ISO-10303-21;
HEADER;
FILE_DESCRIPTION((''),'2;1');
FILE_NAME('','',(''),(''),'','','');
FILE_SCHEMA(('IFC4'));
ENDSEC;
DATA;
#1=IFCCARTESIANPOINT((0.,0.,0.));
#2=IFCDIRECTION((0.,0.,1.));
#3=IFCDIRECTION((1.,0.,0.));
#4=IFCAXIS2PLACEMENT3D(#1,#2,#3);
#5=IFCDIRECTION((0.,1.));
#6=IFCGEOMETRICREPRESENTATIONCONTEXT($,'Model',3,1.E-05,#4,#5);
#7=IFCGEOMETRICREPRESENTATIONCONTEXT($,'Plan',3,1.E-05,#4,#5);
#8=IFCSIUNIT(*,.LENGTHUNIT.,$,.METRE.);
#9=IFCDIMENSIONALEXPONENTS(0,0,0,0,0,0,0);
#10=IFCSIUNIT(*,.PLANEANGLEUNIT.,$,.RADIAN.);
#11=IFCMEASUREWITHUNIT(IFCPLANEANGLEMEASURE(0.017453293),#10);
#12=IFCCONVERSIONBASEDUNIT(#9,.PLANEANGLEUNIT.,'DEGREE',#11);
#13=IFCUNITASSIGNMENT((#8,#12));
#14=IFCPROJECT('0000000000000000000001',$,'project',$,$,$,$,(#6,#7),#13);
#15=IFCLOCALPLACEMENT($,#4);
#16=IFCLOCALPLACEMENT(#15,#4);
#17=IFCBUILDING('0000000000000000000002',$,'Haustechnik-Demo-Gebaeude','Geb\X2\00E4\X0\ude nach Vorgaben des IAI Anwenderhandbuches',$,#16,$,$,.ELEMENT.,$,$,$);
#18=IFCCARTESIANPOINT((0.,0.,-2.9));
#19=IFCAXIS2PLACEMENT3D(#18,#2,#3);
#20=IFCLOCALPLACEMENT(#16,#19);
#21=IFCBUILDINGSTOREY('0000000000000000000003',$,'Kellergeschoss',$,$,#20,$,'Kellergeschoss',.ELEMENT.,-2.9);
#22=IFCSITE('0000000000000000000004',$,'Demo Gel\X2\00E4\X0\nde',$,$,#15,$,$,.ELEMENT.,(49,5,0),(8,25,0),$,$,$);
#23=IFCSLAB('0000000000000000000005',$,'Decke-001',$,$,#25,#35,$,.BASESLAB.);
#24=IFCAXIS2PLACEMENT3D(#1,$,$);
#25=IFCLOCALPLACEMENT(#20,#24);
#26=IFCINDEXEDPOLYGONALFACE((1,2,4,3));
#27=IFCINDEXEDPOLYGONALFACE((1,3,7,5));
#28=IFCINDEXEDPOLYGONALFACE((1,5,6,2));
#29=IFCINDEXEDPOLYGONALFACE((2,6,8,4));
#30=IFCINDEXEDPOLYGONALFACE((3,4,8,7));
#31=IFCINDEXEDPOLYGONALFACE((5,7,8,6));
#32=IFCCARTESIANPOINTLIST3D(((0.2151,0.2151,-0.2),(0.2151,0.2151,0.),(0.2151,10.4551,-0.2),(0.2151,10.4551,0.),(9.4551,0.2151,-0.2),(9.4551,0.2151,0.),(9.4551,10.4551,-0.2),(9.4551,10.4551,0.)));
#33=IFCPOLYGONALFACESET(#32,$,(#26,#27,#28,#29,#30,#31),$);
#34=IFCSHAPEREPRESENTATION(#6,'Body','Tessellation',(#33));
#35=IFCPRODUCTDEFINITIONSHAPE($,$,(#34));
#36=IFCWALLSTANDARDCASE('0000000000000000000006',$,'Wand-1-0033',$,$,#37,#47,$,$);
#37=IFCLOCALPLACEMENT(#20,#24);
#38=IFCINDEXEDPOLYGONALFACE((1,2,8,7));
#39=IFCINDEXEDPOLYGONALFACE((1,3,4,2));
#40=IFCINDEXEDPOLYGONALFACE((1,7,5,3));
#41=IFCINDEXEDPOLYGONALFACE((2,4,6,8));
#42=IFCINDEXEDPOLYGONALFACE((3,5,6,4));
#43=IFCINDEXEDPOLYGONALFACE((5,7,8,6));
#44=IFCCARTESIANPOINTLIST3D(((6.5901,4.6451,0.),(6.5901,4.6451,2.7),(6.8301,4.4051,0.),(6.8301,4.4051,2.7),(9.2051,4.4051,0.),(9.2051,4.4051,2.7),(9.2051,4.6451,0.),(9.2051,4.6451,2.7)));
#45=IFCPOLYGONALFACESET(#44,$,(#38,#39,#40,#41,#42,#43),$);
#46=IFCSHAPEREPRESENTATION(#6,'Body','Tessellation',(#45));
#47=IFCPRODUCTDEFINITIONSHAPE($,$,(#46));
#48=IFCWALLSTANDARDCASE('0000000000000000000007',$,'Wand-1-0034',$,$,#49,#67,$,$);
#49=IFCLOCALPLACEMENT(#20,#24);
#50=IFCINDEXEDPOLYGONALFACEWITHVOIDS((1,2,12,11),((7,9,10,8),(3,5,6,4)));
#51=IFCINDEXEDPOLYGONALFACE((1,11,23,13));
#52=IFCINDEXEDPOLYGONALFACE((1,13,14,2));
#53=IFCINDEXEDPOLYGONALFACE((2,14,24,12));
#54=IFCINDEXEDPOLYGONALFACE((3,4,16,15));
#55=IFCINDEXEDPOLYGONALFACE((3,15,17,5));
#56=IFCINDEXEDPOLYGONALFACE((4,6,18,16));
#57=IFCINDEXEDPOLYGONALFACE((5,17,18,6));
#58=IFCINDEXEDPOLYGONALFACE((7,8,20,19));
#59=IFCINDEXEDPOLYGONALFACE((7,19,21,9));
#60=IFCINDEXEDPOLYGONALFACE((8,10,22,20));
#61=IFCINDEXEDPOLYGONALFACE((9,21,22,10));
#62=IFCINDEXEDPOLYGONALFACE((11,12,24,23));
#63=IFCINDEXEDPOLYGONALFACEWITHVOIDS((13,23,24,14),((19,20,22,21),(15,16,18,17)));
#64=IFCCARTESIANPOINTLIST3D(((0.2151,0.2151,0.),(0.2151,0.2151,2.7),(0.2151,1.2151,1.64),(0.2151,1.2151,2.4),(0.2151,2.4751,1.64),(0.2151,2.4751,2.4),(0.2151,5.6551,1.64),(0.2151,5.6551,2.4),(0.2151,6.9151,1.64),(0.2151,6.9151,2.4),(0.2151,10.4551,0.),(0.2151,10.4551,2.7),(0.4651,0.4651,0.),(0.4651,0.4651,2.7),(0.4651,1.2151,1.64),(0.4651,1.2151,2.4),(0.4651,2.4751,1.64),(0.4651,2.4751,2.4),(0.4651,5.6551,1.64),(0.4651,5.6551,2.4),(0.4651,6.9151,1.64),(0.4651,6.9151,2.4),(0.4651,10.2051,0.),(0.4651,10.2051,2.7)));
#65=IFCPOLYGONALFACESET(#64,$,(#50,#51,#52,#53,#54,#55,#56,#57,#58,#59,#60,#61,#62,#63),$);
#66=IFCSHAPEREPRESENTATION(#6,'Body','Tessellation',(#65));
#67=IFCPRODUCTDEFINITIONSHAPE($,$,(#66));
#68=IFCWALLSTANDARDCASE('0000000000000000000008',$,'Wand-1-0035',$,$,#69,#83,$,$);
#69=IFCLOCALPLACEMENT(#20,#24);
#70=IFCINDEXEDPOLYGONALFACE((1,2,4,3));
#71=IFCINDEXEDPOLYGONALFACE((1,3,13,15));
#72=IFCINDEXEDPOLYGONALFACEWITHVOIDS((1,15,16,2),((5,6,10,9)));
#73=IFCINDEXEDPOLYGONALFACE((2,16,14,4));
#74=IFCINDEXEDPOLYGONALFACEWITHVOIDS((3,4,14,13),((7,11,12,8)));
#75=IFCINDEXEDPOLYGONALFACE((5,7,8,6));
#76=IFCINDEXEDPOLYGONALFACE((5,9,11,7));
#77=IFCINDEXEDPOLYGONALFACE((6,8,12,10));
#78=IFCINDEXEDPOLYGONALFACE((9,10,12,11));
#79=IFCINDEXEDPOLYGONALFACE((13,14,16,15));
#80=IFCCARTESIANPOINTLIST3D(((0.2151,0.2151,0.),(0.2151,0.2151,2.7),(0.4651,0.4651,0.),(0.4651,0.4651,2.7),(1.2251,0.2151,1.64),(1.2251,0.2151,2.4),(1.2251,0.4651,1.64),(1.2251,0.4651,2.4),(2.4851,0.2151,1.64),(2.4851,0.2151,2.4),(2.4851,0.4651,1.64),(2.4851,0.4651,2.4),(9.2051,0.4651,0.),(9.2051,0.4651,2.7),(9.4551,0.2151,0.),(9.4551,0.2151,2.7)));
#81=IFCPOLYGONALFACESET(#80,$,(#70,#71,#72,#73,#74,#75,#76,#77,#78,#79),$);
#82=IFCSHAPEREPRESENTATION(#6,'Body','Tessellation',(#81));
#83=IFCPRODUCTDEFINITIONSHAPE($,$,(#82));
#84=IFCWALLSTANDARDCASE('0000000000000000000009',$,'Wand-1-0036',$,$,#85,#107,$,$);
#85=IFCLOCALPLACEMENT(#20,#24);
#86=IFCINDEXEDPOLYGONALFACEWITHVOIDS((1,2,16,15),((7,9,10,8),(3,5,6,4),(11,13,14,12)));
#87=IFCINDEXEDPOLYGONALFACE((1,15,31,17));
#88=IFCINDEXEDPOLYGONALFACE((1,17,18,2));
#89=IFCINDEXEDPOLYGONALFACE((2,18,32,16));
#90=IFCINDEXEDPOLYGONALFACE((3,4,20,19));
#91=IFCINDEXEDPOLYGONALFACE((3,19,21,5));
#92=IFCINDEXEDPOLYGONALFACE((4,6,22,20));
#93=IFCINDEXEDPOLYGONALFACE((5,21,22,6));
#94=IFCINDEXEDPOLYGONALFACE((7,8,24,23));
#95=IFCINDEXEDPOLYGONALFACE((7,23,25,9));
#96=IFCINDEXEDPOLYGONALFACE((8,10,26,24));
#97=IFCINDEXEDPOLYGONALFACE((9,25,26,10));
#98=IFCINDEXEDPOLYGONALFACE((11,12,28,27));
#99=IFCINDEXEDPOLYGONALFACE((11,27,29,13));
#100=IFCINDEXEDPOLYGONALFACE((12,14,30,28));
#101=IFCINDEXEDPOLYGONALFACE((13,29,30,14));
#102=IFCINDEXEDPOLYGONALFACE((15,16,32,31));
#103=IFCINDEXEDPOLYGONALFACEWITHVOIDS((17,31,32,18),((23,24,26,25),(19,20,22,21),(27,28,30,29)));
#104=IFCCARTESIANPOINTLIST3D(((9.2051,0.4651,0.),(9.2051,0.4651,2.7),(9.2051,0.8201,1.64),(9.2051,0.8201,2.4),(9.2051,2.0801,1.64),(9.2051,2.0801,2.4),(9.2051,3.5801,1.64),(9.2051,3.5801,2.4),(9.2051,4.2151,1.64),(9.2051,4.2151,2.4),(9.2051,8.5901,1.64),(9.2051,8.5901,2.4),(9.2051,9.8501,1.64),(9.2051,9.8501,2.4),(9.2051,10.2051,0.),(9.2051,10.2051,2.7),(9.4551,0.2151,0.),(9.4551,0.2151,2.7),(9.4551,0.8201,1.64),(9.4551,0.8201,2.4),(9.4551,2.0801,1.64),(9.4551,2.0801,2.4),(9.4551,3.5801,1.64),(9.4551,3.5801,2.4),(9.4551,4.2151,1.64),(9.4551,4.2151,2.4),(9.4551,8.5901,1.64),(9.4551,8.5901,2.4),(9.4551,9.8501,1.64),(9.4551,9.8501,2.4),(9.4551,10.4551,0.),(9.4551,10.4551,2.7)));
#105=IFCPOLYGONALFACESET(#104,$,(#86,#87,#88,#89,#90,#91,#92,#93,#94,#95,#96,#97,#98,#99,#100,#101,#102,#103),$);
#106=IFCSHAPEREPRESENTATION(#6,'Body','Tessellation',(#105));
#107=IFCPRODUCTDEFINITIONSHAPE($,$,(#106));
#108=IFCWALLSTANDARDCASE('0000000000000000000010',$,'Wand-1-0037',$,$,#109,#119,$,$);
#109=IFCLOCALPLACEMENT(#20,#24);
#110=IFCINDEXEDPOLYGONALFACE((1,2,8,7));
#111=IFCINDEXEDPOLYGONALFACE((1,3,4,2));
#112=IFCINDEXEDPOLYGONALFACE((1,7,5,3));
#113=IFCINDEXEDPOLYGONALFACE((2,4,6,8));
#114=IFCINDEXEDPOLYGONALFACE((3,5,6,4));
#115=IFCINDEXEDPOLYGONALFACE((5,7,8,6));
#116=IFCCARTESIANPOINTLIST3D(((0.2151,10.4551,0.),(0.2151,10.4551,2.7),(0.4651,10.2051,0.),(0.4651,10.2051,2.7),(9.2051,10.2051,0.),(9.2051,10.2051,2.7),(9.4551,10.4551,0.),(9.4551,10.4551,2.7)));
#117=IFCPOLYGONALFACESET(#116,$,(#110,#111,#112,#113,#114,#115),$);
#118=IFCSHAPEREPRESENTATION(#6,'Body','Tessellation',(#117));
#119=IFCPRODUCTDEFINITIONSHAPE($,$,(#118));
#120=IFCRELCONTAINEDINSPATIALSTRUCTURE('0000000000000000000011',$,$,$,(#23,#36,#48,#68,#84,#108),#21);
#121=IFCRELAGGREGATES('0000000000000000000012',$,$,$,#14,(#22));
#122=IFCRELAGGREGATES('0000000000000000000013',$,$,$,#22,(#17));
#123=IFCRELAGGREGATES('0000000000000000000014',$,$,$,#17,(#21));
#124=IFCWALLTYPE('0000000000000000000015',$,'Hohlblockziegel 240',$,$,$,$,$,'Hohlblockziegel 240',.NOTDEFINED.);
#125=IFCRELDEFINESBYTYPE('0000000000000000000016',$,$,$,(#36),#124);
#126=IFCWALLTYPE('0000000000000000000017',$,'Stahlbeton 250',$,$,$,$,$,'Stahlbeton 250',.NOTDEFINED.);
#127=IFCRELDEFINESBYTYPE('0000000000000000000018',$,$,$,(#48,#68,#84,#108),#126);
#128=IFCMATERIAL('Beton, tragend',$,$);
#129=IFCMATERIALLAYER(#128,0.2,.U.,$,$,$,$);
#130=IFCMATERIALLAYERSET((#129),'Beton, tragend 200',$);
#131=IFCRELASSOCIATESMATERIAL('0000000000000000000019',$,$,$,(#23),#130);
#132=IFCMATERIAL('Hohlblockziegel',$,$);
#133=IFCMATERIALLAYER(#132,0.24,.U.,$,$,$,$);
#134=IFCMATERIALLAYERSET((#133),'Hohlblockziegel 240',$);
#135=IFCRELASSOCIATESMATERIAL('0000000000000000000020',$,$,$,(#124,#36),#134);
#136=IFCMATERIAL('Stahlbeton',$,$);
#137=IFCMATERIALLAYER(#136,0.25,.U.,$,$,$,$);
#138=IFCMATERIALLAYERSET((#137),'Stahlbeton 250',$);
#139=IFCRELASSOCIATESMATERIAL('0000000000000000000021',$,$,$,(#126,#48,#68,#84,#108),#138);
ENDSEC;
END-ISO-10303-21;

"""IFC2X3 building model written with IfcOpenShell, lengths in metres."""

from ifc_helpers import new_model, entity, si_unit, converted_unit, direction, frame, frame_2d, origin_with_axes, place, context, project, spatial, polyline, rectangle, outline, extrude, material, layer, layer_set, layer_usage, type_object, element, save


model = new_model("IFC2X3")

# Units and contexts
model_context = context("Model", 3, precision=1e-05, world=origin_with_axes(), true_north=direction((0.0, 1.0)))
plan_context = context("Plan", 3, precision=1e-05, world=origin_with_axes(), true_north=direction((0.0, 1.0)))
ifc_project = project(units=[si_unit("LENGTHUNIT", "METRE"), converted_unit("PLANEANGLEUNIT", "DEGREE", entity("IfcPlaneAngleMeasure", 0.017453293), si_unit("PLANEANGLEUNIT", "RADIAN"), dimensions=[0, 0, 0, 0, 0, 0, 0])], contexts=[model_context, plan_context])

# Site, building, storey
site_placement = place(None, origin_with_axes())
site = spatial("IfcSite", under=ifc_project, at=site_placement, Name="Demo Gelände", CompositionType="ELEMENT", RefLatitude=(49, 5, 0), RefLongitude=(8, 25, 0))
building_placement = place(site_placement, origin_with_axes())
building = spatial("IfcBuilding", under=site, at=building_placement, Name="Haustechnik-Demo-Gebaeude", Description="Gebäude nach Vorgaben des IAI Anwenderhandbuches", CompositionType="ELEMENT")
storey_placement = place(building_placement, frame((0.0, 0.0, -2.9), z_axis=(0.0, 0.0, 1.0), x_axis=(1.0, 0.0, 0.0)))
storey = spatial("IfcBuildingStorey", under=building, at=storey_placement, Name="Kellergeschoss", LongName="Kellergeschoss", CompositionType="ELEMENT", Elevation=-2.9)

# Slab
ifc_material_1 = material(Name="Beton, tragend")
ifc_layer_1 = layer(ifc_material_1, 0.2, ventilated="UNKNOWN")
ifc_layer_set_1 = layer_set([ifc_layer_1], Name="Beton, tragend 200")
ifc_layer_usage_1 = layer_usage(ifc_layer_set_1, "AXIS3", "NEGATIVE", 0.2)
slab_placement = place(storey_placement, frame((0.2151, 10.4551, -0.2), z_axis=(0.0, 0.0, 1.0), x_axis=(1.0, 0.0, 0.0)))
element("IfcSlab", 1, at=slab_placement, inside=storey, material=ifc_layer_usage_1, Name="Decke-001", PredefinedType="BASESLAB", context=model_context, shape_type="SweptSolid", body=[
    extrude(outline(polyline([(0.0, 0.0), (9.24, 0.0), (9.24, -10.24), (0.0, -10.24), (0.0, 0.0)])), origin_with_axes(), (0.0, 0.0, 1.0), 0.2),
])

# Shared definitions
ifc_material_2 = material(Name="Hohlblockziegel")
ifc_layer_2 = layer(ifc_material_2, 0.24, ventilated="UNKNOWN")
ifc_layer_set_2 = layer_set([ifc_layer_2], Name="Hohlblockziegel 240")
wall_type_1 = type_object("IfcWallType", Name="Hohlblockziegel 240", ElementType="Hohlblockziegel 240", PredefinedType="NOTDEFINED", material=ifc_layer_set_2)

# Wall
ifc_layer_usage_2 = layer_usage(ifc_layer_set_2, "AXIS2", "NEGATIVE", 0.0)
wall_1_placement = place(storey_placement, frame((6.5901, 4.6451, 0.0), z_axis=(0.0, 0.0, 1.0), x_axis=(1.0, 0.0, 0.0)))
element("IfcWallStandardCase", 2, at=wall_1_placement, inside=storey, type_object=wall_type_1, material=ifc_layer_usage_2, Name="Wand-1-0033", context=model_context, shape_type="SweptSolid", body=[
    extrude(outline(polyline([(0.24, -0.24), (2.615, -0.24), (2.615, 0.0), (0.0, 0.0), (0.24, -0.24)])), origin_with_axes(), (0.0, 0.0, 1.0), 2.7),
])

# Wall, openings
ifc_material_3 = material(Name="Stahlbeton")
ifc_layer_3 = layer(ifc_material_3, 0.25, ventilated="UNKNOWN")
ifc_layer_set_3 = layer_set([ifc_layer_3], Name="Stahlbeton 250")
ifc_layer_usage_3 = layer_usage(ifc_layer_set_3, "AXIS2", "POSITIVE", 0.0)
wall_type_2 = type_object("IfcWallType", Name="Stahlbeton 250", ElementType="Stahlbeton 250", PredefinedType="NOTDEFINED", material=ifc_layer_set_3)
wall_2_placement = place(storey_placement, frame((0.2151, 10.4551, 0.0), z_axis=(0.0, 0.0, 1.0), x_axis=(0.0, -1.0, 0.0)))
wall_2 = element("IfcWallStandardCase", 3, at=wall_2_placement, inside=storey, type_object=wall_type_2, material=ifc_layer_usage_3, Name="Wand-1-0034", context=model_context, shape_type="SweptSolid", body=[
    extrude(outline(polyline([(0.0, 0.0), (10.24, 0.0), (9.99, 0.25), (0.25, 0.25), (0.0, 0.0)])), origin_with_axes(), (0.0, 0.0, 1.0), 2.7),
])
opening_1_placement = place(wall_2_placement, frame((8.61, 0.0, 1.64), z_axis=(0.0, 0.0, 1.0), x_axis=(1.0, 0.0, 0.0)))
element("IfcOpeningElement", 4, at=opening_1_placement, cuts=wall_2, ObjectType="Opening", context=model_context, shape_type="SweptSolid", body=[
    extrude(rectangle(XDim=1.26, YDim=0.76, at=frame_2d((0.0, 0.38), x_axis=(-1.0, 0.0))), frame((0.0, 0.0, 0.0), z_axis=(0.0, 1.0, 0.0), x_axis=(-1.0, 0.0, 0.0)), (0.0, 0.0, 1.0), 0.25),
])
opening_2_placement = place(wall_2_placement, frame((4.17, 0.0, 1.64), z_axis=(0.0, 0.0, 1.0), x_axis=(1.0, 0.0, 0.0)))
element("IfcOpeningElement", 5, at=opening_2_placement, cuts=wall_2, ObjectType="Opening", context=model_context, shape_type="SweptSolid", body=[
    extrude(rectangle(XDim=1.26, YDim=0.76, at=frame_2d((0.0, 0.38), x_axis=(-1.0, 0.0))), frame((0.0, 0.0, 0.0), z_axis=(0.0, 1.0, 0.0), x_axis=(-1.0, 0.0, 0.0)), (0.0, 0.0, 1.0), 0.25),
])

# Wall, opening
ifc_layer_usage_4 = layer_usage(ifc_layer_set_3, "AXIS2", "POSITIVE", 0.0)
wall_3_placement = place(storey_placement, frame((0.2151, 0.2151, 0.0), z_axis=(0.0, 0.0, 1.0), x_axis=(1.0, 0.0, 0.0)))
wall_3 = element("IfcWallStandardCase", 6, at=wall_3_placement, inside=storey, type_object=wall_type_2, material=ifc_layer_usage_4, Name="Wand-1-0035", context=model_context, shape_type="SweptSolid", body=[
    extrude(outline(polyline([(0.0, 0.0), (9.24, 0.0), (8.99, 0.25), (0.25, 0.25), (0.0, 0.0)])), origin_with_axes(), (0.0, 0.0, 1.0), 2.7),
])
opening_3_placement = place(wall_3_placement, frame((1.64, 0.0, 1.64), z_axis=(0.0, 0.0, 1.0), x_axis=(1.0, 0.0, 0.0)))
element("IfcOpeningElement", 7, at=opening_3_placement, cuts=wall_3, ObjectType="Opening", context=model_context, shape_type="SweptSolid", body=[
    extrude(rectangle(XDim=1.26, YDim=0.76, at=frame_2d((0.0, 0.38), x_axis=(-1.0, 0.0))), frame((0.0, 0.0, 0.0), z_axis=(0.0, 1.0, 0.0), x_axis=(-1.0, 0.0, 0.0)), (0.0, 0.0, 1.0), 0.25),
])

# Wall, openings
ifc_layer_usage_5 = layer_usage(ifc_layer_set_3, "AXIS2", "POSITIVE", 0.0)
wall_4_placement = place(storey_placement, frame((9.4551, 0.2151, 0.0), z_axis=(0.0, 0.0, 1.0), x_axis=(0.0, 1.0, 0.0)))
wall_4 = element("IfcWallStandardCase", 8, at=wall_4_placement, inside=storey, type_object=wall_type_2, material=ifc_layer_usage_5, Name="Wand-1-0036", context=model_context, shape_type="SweptSolid", body=[
    extrude(outline(polyline([(0.0, 0.0), (10.24, 0.0), (9.99, 0.25), (0.25, 0.25), (0.0, 0.0)])), origin_with_axes(), (0.0, 0.0, 1.0), 2.7),
])
opening_4_placement = place(wall_4_placement, frame((9.005, 0.0, 1.64), z_axis=(0.0, 0.0, 1.0), x_axis=(1.0, 0.0, 0.0)))
element("IfcOpeningElement", 9, at=opening_4_placement, cuts=wall_4, ObjectType="Opening", context=model_context, shape_type="SweptSolid", body=[
    extrude(rectangle(XDim=1.26, YDim=0.76, at=frame_2d((0.0, 0.38), x_axis=(-1.0, 0.0))), frame((0.0, 0.0, 0.0), z_axis=(0.0, 1.0, 0.0), x_axis=(-1.0, 0.0, 0.0)), (0.0, 0.0, 1.0), 0.25),
])
opening_5_placement = place(wall_4_placement, frame((1.235, 0.0, 1.64), z_axis=(0.0, 0.0, 1.0), x_axis=(1.0, 0.0, 0.0)))
element("IfcOpeningElement", 10, at=opening_5_placement, cuts=wall_4, ObjectType="Opening", context=model_context, shape_type="SweptSolid", body=[
    extrude(rectangle(XDim=1.26, YDim=0.76, at=frame_2d((0.0, 0.38), x_axis=(-1.0, 0.0))), frame((0.0, 0.0, 0.0), z_axis=(0.0, 1.0, 0.0), x_axis=(-1.0, 0.0, 0.0)), (0.0, 0.0, 1.0), 0.25),
])
opening_6_placement = place(wall_4_placement, frame((3.6825, 0.0, 1.64), z_axis=(0.0, 0.0, 1.0), x_axis=(1.0, 0.0, 0.0)))
element("IfcOpeningElement", 11, at=opening_6_placement, cuts=wall_4, ObjectType="Opening", context=model_context, shape_type="SweptSolid", body=[
    extrude(rectangle(XDim=0.635, YDim=0.76, at=frame_2d((0.0, 0.38), x_axis=(-1.0, 0.0))), frame((0.0, 0.0, 0.0), z_axis=(0.0, 1.0, 0.0), x_axis=(-1.0, 0.0, 0.0)), (0.0, 0.0, 1.0), 0.25),
])

# Wall
ifc_layer_usage_6 = layer_usage(ifc_layer_set_3, "AXIS2", "POSITIVE", 0.0)
wall_5_placement = place(storey_placement, frame((9.4551, 10.4551, 0.0), z_axis=(0.0, 0.0, 1.0), x_axis=(-1.0, 0.0, 0.0)))
element("IfcWallStandardCase", 12, at=wall_5_placement, inside=storey, type_object=wall_type_2, material=ifc_layer_usage_6, Name="Wand-1-0037", context=model_context, shape_type="SweptSolid", body=[
    extrude(outline(polyline([(0.0, 0.0), (9.24, 0.0), (8.99, 0.25), (0.25, 0.25), (0.0, 0.0)])), origin_with_axes(), (0.0, 0.0, 1.0), 2.7),
])

save(model, "model.ifc")
